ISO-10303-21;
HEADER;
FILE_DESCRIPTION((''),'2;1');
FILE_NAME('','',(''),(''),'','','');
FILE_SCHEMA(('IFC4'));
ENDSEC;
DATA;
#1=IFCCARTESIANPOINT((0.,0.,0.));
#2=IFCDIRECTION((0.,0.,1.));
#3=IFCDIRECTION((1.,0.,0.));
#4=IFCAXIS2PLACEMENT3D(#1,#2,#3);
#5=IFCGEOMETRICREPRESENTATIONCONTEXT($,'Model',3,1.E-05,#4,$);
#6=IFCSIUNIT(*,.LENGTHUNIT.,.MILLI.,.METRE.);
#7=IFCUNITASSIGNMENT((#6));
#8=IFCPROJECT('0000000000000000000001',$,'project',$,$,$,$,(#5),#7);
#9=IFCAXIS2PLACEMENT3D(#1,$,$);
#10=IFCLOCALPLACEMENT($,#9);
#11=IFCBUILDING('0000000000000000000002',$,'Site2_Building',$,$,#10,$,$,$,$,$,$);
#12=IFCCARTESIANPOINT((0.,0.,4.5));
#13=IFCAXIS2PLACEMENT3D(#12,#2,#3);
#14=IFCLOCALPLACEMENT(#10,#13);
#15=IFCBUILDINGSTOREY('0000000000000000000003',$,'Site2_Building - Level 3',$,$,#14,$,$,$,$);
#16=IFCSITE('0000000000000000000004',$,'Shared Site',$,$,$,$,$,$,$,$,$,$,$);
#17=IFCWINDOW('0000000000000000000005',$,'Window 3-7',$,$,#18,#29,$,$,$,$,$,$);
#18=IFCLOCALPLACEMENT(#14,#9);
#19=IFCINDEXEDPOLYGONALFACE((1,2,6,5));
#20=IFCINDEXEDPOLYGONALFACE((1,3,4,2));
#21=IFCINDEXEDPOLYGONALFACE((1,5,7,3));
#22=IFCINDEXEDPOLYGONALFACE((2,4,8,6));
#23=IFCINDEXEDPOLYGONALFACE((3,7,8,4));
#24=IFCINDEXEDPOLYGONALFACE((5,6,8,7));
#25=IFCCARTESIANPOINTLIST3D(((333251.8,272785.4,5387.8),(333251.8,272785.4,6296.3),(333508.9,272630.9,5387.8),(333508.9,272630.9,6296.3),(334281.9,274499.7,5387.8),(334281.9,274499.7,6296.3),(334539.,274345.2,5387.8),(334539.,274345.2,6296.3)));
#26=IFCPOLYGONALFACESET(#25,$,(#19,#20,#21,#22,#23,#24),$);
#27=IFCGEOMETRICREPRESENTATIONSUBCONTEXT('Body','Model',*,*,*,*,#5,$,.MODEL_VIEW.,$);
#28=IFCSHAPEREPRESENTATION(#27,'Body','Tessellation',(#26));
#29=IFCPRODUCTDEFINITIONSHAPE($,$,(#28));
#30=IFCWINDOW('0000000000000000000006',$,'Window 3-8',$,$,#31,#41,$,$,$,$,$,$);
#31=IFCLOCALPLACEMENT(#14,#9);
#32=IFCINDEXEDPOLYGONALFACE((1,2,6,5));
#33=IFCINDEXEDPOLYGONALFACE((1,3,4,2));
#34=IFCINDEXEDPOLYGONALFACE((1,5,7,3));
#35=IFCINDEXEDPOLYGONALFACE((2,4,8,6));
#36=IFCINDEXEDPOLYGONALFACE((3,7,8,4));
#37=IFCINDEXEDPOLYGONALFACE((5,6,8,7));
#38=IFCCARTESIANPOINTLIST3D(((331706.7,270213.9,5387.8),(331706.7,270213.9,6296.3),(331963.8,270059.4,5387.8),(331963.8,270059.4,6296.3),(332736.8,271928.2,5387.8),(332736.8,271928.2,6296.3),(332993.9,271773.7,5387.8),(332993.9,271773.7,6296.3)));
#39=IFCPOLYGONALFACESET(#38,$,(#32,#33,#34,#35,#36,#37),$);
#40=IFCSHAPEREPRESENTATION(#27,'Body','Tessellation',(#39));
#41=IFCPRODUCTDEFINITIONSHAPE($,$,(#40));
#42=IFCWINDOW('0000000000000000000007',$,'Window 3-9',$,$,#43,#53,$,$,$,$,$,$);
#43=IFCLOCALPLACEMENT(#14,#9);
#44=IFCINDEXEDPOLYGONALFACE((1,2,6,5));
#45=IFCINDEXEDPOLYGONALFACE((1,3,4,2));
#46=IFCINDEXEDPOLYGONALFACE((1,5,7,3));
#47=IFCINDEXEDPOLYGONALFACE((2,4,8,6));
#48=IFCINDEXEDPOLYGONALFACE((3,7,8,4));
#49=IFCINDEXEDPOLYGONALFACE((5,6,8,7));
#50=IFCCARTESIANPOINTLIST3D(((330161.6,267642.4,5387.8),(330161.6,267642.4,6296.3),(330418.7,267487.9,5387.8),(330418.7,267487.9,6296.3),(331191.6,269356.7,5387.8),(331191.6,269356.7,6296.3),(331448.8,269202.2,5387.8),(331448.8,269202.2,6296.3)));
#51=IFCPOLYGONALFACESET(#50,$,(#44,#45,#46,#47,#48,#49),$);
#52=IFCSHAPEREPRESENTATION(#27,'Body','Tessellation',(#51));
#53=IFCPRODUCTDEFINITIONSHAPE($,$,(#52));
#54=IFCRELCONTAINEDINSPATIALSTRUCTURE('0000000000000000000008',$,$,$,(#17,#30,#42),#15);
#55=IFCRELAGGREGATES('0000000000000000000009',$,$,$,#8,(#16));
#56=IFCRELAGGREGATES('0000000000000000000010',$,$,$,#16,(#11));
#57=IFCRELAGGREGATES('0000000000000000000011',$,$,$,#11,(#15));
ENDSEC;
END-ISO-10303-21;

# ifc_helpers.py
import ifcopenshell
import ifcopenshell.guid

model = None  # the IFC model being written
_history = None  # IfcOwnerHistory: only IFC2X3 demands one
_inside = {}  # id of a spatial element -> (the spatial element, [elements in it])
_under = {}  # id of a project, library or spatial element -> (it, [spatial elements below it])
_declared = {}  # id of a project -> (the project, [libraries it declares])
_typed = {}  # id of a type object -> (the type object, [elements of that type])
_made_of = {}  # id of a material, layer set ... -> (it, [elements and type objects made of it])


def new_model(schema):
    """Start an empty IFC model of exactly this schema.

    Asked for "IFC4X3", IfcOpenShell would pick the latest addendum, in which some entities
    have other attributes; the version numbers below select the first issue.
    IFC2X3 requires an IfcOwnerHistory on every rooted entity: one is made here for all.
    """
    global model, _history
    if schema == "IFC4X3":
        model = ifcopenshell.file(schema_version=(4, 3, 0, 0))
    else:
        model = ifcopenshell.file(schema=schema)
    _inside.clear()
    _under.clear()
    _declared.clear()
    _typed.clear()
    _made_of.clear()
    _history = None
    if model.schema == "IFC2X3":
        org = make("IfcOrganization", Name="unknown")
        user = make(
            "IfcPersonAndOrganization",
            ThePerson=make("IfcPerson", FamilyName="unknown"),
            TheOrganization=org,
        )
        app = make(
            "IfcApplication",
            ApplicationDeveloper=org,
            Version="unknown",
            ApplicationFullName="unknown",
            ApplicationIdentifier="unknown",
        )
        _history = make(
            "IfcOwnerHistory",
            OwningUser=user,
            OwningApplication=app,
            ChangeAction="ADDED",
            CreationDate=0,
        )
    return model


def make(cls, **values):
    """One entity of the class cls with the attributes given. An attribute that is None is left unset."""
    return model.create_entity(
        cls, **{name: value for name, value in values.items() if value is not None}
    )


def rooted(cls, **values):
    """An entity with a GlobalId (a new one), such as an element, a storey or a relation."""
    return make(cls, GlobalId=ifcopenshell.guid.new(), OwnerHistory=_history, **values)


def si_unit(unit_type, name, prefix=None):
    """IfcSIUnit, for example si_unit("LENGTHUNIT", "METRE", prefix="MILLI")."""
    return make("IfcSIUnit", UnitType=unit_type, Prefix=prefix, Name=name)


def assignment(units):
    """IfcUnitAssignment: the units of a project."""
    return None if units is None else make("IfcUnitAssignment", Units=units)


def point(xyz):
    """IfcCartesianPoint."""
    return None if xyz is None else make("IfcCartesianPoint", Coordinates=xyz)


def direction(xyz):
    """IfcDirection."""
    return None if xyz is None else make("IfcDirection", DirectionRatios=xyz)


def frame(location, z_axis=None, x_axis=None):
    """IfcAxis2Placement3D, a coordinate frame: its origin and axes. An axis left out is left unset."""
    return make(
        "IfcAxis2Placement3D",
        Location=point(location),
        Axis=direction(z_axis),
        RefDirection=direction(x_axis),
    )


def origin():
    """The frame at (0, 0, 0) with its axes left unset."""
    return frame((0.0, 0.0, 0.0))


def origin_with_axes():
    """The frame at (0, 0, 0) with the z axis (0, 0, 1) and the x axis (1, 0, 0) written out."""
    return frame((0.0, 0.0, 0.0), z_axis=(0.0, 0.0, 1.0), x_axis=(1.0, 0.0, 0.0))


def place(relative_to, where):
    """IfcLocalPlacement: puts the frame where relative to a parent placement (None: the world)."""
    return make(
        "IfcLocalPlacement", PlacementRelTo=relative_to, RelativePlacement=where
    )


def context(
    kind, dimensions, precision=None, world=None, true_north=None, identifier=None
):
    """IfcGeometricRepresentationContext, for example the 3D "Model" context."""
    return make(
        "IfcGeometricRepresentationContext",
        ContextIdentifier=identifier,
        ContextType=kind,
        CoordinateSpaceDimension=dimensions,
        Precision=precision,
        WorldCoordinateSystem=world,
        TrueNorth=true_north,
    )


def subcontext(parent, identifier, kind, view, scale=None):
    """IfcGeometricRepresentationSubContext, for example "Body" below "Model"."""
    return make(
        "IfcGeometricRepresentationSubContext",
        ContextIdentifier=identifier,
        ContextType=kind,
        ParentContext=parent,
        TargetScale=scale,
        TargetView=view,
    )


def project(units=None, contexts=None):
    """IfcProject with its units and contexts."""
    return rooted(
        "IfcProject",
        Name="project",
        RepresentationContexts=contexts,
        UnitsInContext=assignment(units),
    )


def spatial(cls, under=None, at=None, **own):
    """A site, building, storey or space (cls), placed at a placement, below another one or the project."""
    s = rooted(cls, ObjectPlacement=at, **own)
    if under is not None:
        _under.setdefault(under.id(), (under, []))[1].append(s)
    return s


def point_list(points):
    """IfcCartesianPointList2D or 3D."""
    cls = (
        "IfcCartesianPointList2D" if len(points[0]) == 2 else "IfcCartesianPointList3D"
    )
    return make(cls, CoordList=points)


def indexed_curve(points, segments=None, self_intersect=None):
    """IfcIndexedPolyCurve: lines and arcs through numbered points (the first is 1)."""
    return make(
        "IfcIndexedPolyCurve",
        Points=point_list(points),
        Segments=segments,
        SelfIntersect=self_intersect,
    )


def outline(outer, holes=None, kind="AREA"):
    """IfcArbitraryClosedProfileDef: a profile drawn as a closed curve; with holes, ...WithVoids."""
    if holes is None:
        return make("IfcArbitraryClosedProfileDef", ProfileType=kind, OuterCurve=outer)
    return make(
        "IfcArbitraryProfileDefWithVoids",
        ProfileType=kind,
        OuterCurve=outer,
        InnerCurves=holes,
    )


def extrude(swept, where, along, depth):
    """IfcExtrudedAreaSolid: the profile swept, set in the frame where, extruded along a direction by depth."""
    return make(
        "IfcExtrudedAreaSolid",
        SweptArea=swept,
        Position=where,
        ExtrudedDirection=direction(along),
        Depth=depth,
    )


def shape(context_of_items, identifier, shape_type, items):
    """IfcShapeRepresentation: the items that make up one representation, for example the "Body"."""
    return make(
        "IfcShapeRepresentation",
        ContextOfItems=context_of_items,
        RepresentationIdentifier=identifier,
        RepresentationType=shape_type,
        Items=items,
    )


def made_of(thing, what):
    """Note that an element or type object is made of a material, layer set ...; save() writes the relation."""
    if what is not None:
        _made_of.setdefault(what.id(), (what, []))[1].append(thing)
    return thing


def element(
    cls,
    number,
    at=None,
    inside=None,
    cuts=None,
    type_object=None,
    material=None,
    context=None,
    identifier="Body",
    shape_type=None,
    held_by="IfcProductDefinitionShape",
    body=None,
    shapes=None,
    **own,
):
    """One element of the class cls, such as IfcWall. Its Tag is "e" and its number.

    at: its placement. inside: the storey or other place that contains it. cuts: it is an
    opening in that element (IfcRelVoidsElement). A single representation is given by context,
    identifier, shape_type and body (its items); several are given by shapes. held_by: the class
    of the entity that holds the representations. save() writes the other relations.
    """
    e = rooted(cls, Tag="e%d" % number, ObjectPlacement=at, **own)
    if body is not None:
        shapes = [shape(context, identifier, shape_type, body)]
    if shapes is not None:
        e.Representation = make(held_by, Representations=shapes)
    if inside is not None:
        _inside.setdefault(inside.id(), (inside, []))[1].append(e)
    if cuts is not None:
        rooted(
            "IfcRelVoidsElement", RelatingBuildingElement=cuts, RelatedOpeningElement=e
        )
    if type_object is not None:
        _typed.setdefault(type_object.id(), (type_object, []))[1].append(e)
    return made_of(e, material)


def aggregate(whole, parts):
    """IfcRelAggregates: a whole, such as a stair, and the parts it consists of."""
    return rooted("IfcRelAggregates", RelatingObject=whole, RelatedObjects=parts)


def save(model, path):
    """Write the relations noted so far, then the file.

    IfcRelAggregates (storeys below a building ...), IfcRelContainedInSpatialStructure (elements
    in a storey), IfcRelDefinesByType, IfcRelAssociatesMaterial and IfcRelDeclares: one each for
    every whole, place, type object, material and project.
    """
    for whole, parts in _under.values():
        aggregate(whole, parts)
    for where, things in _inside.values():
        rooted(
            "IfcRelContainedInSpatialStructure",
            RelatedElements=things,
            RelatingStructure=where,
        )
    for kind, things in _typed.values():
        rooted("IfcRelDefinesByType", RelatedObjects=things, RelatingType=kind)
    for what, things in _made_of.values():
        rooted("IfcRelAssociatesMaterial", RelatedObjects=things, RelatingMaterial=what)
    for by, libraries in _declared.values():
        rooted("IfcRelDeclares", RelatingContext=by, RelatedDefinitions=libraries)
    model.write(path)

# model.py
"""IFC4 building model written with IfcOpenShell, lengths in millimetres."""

from ifc_helpers import new_model, si_unit, frame, origin, origin_with_axes, place, context, subcontext, project, spatial, indexed_curve, outline, extrude, element, save


model = new_model("IFC4")

# Units and contexts
model_context = context("Model", 3, precision=1e-05, world=origin_with_axes())
body_context = subcontext(model_context, "Body", "Model", "MODEL_VIEW")
ifc_project = project(units=[si_unit("LENGTHUNIT", "METRE", prefix="MILLI")], contexts=[model_context])

# Site, building, storey
site = spatial("IfcSite", under=ifc_project, Name="Shared Site")
building_placement = place(None, origin())
building = spatial("IfcBuilding", under=site, at=building_placement, Name="Site2_Building")
storey_placement = place(building_placement, frame((0.0, 0.0, 4.5), z_axis=(0.0, 0.0, 1.0), x_axis=(1.0, 0.0, 0.0)))
storey = spatial("IfcBuildingStorey", under=building, at=storey_placement, Name="Site2_Building - Level 3")

# Windows
for number, where, z_axis, x_axis, name in (
    (1, (334281.9, 274499.7, 5387.8), (0.0, 0.0, 1.0), (-0.515038, -0.857167, 0.0), "Window 3-7"),
    (2, (332736.8, 271928.2, 5387.8), (0.0, 0.0, 1.0), (-0.515038, -0.857167, 0.0), "Window 3-8"),
    (3, (331191.6, 269356.7, 5387.8), (0.0, 0.0, 1.0), (-0.515038, -0.857167, 0.0), "Window 3-9"),
):
    element("IfcWindow", number, at=place(storey_placement, frame(where, z_axis=z_axis, x_axis=x_axis)), inside=storey, Name=name, context=body_context, shape_type="SweptSolid", body=[
        extrude(outline(indexed_curve([(0.0, 0.0), (0.0, 300.0), (2000.0, 300.0), (2000.0, 0.0), (0.0, 0.0)], self_intersect=False)), origin_with_axes(), (0.0, 0.0, 1.0), 908.6),
    ])

save(model, "model.ifc")
